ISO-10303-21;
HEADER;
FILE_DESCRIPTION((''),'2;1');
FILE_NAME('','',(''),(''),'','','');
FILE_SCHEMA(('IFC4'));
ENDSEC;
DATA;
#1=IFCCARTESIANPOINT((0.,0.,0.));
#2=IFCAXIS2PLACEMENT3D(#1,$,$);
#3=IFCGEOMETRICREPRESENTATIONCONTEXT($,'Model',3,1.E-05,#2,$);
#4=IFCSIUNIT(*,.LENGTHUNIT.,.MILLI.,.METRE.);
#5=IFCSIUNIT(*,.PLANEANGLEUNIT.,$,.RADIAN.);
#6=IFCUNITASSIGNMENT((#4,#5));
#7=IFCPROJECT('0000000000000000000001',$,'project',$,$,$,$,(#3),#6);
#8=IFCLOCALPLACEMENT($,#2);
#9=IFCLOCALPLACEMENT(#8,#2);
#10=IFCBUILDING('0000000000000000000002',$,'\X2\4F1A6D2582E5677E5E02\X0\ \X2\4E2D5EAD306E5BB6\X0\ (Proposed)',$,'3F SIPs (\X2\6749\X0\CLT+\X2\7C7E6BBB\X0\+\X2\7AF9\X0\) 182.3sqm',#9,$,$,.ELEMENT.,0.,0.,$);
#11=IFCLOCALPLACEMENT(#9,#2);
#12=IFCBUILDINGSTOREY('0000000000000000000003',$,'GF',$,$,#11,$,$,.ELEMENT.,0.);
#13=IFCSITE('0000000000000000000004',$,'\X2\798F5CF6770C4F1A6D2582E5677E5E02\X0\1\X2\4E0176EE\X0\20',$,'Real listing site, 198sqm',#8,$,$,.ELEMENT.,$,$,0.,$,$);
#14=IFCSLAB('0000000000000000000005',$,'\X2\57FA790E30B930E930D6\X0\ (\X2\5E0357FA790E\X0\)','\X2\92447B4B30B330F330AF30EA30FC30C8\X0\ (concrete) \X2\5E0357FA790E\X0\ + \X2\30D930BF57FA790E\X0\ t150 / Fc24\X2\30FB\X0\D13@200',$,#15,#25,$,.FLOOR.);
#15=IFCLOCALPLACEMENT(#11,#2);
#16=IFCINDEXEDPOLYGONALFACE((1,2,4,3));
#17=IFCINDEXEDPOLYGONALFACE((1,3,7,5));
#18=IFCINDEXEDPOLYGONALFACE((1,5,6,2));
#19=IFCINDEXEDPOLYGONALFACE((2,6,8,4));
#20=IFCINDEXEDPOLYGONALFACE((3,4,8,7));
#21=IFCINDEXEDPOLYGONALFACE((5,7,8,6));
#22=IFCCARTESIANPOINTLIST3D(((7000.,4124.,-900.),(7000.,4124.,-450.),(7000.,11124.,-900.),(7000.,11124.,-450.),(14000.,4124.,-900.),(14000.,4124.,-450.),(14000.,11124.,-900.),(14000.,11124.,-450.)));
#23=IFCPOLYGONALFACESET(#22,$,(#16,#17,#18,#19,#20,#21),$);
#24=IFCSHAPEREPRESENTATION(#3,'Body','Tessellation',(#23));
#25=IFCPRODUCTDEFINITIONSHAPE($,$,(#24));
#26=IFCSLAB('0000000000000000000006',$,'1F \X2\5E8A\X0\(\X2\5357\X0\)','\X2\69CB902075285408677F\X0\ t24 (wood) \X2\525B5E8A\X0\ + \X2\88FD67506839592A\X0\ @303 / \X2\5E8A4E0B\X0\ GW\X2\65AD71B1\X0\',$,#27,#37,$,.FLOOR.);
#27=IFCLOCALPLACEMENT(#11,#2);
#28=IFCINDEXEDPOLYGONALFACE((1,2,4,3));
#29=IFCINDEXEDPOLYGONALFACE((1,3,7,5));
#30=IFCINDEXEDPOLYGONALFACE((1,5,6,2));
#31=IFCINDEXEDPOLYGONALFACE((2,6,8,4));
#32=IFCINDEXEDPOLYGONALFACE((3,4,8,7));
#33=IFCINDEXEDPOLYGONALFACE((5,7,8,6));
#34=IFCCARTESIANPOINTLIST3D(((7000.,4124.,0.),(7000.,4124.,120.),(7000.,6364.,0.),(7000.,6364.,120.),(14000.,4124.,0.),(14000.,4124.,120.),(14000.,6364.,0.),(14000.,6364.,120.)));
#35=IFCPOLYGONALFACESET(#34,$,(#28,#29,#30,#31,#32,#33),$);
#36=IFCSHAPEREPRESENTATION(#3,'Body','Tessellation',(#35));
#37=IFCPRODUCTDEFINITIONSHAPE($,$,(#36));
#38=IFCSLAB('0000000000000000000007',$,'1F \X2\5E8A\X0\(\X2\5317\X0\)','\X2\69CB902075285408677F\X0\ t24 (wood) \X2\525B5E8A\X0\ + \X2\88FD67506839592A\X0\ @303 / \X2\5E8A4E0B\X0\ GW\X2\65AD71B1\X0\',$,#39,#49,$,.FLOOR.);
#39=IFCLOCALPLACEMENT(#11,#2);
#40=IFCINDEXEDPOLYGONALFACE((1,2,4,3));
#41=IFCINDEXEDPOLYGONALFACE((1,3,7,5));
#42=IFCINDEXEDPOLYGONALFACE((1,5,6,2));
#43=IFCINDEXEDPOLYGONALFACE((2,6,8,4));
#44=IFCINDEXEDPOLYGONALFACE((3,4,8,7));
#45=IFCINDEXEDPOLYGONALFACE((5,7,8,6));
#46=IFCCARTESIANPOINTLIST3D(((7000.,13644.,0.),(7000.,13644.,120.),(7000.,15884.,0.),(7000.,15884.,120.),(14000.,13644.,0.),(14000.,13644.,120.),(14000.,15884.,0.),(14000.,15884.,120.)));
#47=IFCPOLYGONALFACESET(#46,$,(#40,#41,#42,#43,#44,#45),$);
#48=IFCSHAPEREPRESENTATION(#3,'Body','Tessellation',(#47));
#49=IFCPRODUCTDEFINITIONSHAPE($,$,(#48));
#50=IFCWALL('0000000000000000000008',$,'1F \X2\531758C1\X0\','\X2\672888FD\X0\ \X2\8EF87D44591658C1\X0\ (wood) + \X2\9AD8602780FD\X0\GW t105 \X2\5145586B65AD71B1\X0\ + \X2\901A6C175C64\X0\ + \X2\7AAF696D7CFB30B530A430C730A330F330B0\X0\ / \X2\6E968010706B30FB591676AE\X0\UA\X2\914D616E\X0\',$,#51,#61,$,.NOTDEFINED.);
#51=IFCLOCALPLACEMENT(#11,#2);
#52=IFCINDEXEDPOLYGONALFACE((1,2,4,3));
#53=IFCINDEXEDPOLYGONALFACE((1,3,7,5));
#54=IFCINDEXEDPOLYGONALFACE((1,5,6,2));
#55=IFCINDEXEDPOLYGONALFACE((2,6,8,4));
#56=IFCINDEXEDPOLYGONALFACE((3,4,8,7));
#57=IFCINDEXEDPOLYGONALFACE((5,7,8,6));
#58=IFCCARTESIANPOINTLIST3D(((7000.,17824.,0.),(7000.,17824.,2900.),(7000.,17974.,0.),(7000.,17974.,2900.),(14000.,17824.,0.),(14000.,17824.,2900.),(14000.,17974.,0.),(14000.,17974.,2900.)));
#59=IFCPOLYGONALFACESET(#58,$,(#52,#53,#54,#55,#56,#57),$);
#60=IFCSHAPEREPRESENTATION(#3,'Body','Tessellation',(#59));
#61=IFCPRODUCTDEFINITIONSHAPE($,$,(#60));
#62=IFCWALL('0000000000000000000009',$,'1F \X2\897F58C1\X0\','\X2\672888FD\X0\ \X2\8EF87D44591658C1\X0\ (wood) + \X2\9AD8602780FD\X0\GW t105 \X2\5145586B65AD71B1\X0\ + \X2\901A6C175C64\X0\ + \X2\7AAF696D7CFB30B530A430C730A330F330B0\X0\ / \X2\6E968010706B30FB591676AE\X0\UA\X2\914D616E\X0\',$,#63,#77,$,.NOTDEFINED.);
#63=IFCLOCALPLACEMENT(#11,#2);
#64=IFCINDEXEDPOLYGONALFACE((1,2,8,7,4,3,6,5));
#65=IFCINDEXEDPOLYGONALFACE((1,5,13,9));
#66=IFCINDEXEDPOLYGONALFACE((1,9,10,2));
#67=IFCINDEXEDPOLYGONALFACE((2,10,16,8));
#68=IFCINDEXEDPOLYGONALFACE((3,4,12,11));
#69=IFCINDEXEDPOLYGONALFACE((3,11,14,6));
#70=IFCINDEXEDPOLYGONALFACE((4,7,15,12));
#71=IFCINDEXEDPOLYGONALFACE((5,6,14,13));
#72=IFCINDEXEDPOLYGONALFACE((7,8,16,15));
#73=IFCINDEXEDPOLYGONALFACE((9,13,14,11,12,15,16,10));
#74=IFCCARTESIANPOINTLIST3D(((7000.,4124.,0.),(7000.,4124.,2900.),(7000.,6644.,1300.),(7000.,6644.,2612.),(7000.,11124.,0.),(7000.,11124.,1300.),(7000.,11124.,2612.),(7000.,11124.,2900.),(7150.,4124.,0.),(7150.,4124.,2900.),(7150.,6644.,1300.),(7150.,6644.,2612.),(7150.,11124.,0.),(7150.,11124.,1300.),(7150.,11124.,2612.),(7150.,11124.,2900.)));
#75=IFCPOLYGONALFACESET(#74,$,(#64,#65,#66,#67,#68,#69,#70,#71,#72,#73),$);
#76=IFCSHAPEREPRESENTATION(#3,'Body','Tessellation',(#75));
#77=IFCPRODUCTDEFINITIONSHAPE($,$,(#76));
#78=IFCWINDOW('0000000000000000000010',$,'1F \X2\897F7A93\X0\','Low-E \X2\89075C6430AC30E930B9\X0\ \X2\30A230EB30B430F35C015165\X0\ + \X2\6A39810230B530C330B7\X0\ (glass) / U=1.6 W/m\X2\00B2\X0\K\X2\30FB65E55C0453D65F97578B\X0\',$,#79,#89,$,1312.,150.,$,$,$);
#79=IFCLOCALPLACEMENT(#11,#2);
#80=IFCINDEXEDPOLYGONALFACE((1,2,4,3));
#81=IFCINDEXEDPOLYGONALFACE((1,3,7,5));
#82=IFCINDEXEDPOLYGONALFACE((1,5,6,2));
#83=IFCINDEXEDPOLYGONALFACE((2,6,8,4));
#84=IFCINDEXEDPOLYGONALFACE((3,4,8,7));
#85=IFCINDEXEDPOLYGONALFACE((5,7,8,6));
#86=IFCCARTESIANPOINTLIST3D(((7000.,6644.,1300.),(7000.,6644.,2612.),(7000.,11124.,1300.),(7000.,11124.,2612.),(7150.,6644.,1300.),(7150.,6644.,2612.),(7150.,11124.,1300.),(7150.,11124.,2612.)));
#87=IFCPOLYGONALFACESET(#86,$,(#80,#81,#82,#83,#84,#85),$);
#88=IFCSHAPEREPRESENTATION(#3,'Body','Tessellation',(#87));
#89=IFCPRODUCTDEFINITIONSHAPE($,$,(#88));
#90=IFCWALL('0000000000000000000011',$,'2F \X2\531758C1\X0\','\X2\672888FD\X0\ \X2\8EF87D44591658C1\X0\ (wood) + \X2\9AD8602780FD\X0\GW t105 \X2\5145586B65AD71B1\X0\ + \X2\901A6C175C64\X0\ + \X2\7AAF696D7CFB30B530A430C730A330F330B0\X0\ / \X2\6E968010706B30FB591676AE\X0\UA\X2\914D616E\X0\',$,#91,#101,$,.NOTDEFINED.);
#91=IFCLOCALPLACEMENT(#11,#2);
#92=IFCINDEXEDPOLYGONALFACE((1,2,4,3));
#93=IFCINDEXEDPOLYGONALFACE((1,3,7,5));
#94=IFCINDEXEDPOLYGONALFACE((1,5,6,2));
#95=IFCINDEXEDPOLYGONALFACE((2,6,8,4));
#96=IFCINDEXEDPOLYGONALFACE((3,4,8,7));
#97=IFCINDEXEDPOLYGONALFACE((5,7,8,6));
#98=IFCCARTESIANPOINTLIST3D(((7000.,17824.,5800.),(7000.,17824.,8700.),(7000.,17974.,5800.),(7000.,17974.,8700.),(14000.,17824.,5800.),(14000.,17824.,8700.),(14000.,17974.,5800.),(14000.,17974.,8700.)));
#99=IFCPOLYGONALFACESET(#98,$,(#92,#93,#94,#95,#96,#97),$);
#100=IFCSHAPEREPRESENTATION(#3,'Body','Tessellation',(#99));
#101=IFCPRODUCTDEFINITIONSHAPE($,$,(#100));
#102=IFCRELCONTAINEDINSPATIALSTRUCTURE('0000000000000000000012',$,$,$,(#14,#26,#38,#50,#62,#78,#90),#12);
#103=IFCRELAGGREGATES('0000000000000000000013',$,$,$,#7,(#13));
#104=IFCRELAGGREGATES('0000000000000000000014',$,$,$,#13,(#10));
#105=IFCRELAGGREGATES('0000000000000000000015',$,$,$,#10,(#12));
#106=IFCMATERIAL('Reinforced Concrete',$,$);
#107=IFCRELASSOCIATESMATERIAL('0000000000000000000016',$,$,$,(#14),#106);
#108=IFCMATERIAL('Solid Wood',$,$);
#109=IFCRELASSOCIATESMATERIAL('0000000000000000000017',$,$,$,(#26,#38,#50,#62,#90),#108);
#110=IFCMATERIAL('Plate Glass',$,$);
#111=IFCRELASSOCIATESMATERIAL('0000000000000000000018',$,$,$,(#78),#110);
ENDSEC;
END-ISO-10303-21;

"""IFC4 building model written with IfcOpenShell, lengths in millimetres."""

from ifc_helpers import new_model, si_unit, frame, frame_2d, origin, place, context, project, spatial, rectangle, extrude, material, element, fill, save


model = new_model("IFC4")

# Units and contexts
model_context = context("Model", 3, precision=1e-05, world=origin())
ifc_project = project(units=[si_unit("LENGTHUNIT", "METRE", prefix="MILLI"), si_unit("PLANEANGLEUNIT", "RADIAN")], contexts=[model_context])

# Site, building, storey
site_placement = place(None, origin())
site = spatial("IfcSite", under=ifc_project, at=site_placement, Name="福島県会津若松市1丁目20", ObjectType="Real listing site, 198sqm", CompositionType="ELEMENT", RefElevation=0.0)
building_placement = place(site_placement, origin())
building = spatial("IfcBuilding", under=site, at=building_placement, Name="会津若松市 中庭の家 (Proposed)", ObjectType="3F SIPs (杉CLT+籾殻+竹) 182.3sqm", CompositionType="ELEMENT", ElevationOfRefHeight=0.0, ElevationOfTerrain=0.0)
storey_placement = place(building_placement, origin())
storey = spatial("IfcBuildingStorey", under=building, at=storey_placement, Name="GF", CompositionType="ELEMENT", Elevation=0.0)

# Slabs
ifc_material_1 = material(Name="Reinforced Concrete")
slab_1_placement = place(storey_placement, frame((3500.0, 2062.0, -450.0)))
element("IfcSlab", 1, at=slab_1_placement, inside=storey, material=ifc_material_1, Name="基礎スラブ (布基礎)", Description="鉄筋コンクリート (concrete) 布基礎 + ベタ基礎 t150 / Fc24・D13@200", PredefinedType="FLOOR", context=model_context, shape_type="SweptSolid", body=[
    extrude(rectangle(XDim=7000.0, YDim=7000.0, at=frame_2d((3500.0, 3500.0))), frame((3500.0, 2062.0, -450.0)), (0.0, 0.0, 1.0), 450.0),
])
ifc_material_2 = material(Name="Solid Wood")
slab_2_placement = place(storey_placement, frame((3500.0, 2062.0, 0.0)))
element("IfcSlab", 2, at=slab_2_placement, inside=storey, material=ifc_material_2, Name="1F 床(南)", Description="構造用合板 t24 (wood) 剛床 + 製材根太 @303 / 床下 GW断熱", PredefinedType="FLOOR", context=model_context, shape_type="SweptSolid", body=[
    extrude(rectangle(XDim=7000.0, YDim=2240.0, at=frame_2d((3500.0, 1120.0))), frame((3500.0, 2062.0, 0.0)), (0.0, 0.0, 1.0), 120.0),
])
slab_3_placement = place(storey_placement, frame((3500.0, 6822.0, 0.0)))
element("IfcSlab", 3, at=slab_3_placement, inside=storey, material=ifc_material_2, Name="1F 床(北)", Description="構造用合板 t24 (wood) 剛床 + 製材根太 @303 / 床下 GW断熱", PredefinedType="FLOOR", context=model_context, shape_type="SweptSolid", body=[
    extrude(rectangle(XDim=7000.0, YDim=2240.0, at=frame_2d((3500.0, 1120.0))), frame((3500.0, 6822.0, 0.0)), (0.0, 0.0, 1.0), 120.0),
])

# Shared definitions
ifc_material_3 = material(Name="Plate Glass")

# Wall
wall_1_placement = place(storey_placement, frame((3500.0, 8912.0, 0.0)))
element("IfcWall", 4, at=wall_1_placement, inside=storey, material=ifc_material_2, Name="1F 北壁", Description="木製 軸組外壁 (wood) + 高性能GW t105 充填断熱 + 通気層 + 窯業系サイディング / 準耐火・外皮UA配慮", PredefinedType="NOTDEFINED", context=model_context, shape_type="SweptSolid", body=[
    extrude(rectangle(XDim=7000.0, YDim=150.0, at=frame_2d((3500.0, 75.0))), frame((3500.0, 8912.0, 0.0)), (0.0, 0.0, 1.0), 2900.0),
])

# Wall, opening, window
wall_2_placement = place(storey_placement, frame((3500.0, 2062.0, 0.0)))
wall_2 = element("IfcWall", 5, at=wall_2_placement, inside=storey, material=ifc_material_2, Name="1F 西壁", Description="木製 軸組外壁 (wood) + 高性能GW t105 充填断熱 + 通気層 + 窯業系サイディング / 準耐火・外皮UA配慮", PredefinedType="NOTDEFINED", context=model_context, shape_type="SweptSolid", body=[
    extrude(rectangle(XDim=150.0, YDim=7000.0, at=frame_2d((75.0, 3500.0))), frame((3500.0, 2062.0, 0.0)), (0.0, 0.0, 1.0), 2900.0),
])
opening_1_placement = place(storey_placement, frame((3500.0, 3322.0, 650.0)))
opening_1 = element("IfcOpeningElement", 6, at=opening_1_placement, cuts=wall_2, PredefinedType="NOTDEFINED", context=model_context, shape_type="SweptSolid", body=[
    extrude(rectangle(XDim=150.0, YDim=4480.0, at=frame_2d((75.0, 2240.0))), frame((3500.0, 3322.0, 650.0)), (0.0, 0.0, 1.0), 1312.0),
])
window_1_placement = place(storey_placement, frame((3500.0, 3322.0, 650.0)))
window_1 = element("IfcWindow", 7, at=window_1_placement, inside=storey, material=ifc_material_3, Name="1F 西窓", Description="Low-E 複層ガラス アルゴン封入 + 樹脂サッシ (glass) / U=1.6 W/m²K・日射取得型", OverallHeight=1312.0, OverallWidth=150.0, context=model_context, shape_type="SweptSolid", body=[
    extrude(rectangle(XDim=150.0, YDim=4480.0, at=frame_2d((75.0, 2240.0))), frame((3500.0, 3322.0, 650.0)), (0.0, 0.0, 1.0), 1312.0),
])
fill(opening_1, window_1)

# Wall
wall_3_placement = place(storey_placement, frame((3500.0, 8912.0, 2900.0)))
element("IfcWall", 8, at=wall_3_placement, inside=storey, material=ifc_material_2, Name="2F 北壁", Description="木製 軸組外壁 (wood) + 高性能GW t105 充填断熱 + 通気層 + 窯業系サイディング / 準耐火・外皮UA配慮", PredefinedType="NOTDEFINED", context=model_context, shape_type="SweptSolid", body=[
    extrude(rectangle(XDim=7000.0, YDim=150.0, at=frame_2d((3500.0, 75.0))), frame((3500.0, 8912.0, 2900.0)), (0.0, 0.0, 1.0), 2900.0),
])

save(model, "model.ifc")
